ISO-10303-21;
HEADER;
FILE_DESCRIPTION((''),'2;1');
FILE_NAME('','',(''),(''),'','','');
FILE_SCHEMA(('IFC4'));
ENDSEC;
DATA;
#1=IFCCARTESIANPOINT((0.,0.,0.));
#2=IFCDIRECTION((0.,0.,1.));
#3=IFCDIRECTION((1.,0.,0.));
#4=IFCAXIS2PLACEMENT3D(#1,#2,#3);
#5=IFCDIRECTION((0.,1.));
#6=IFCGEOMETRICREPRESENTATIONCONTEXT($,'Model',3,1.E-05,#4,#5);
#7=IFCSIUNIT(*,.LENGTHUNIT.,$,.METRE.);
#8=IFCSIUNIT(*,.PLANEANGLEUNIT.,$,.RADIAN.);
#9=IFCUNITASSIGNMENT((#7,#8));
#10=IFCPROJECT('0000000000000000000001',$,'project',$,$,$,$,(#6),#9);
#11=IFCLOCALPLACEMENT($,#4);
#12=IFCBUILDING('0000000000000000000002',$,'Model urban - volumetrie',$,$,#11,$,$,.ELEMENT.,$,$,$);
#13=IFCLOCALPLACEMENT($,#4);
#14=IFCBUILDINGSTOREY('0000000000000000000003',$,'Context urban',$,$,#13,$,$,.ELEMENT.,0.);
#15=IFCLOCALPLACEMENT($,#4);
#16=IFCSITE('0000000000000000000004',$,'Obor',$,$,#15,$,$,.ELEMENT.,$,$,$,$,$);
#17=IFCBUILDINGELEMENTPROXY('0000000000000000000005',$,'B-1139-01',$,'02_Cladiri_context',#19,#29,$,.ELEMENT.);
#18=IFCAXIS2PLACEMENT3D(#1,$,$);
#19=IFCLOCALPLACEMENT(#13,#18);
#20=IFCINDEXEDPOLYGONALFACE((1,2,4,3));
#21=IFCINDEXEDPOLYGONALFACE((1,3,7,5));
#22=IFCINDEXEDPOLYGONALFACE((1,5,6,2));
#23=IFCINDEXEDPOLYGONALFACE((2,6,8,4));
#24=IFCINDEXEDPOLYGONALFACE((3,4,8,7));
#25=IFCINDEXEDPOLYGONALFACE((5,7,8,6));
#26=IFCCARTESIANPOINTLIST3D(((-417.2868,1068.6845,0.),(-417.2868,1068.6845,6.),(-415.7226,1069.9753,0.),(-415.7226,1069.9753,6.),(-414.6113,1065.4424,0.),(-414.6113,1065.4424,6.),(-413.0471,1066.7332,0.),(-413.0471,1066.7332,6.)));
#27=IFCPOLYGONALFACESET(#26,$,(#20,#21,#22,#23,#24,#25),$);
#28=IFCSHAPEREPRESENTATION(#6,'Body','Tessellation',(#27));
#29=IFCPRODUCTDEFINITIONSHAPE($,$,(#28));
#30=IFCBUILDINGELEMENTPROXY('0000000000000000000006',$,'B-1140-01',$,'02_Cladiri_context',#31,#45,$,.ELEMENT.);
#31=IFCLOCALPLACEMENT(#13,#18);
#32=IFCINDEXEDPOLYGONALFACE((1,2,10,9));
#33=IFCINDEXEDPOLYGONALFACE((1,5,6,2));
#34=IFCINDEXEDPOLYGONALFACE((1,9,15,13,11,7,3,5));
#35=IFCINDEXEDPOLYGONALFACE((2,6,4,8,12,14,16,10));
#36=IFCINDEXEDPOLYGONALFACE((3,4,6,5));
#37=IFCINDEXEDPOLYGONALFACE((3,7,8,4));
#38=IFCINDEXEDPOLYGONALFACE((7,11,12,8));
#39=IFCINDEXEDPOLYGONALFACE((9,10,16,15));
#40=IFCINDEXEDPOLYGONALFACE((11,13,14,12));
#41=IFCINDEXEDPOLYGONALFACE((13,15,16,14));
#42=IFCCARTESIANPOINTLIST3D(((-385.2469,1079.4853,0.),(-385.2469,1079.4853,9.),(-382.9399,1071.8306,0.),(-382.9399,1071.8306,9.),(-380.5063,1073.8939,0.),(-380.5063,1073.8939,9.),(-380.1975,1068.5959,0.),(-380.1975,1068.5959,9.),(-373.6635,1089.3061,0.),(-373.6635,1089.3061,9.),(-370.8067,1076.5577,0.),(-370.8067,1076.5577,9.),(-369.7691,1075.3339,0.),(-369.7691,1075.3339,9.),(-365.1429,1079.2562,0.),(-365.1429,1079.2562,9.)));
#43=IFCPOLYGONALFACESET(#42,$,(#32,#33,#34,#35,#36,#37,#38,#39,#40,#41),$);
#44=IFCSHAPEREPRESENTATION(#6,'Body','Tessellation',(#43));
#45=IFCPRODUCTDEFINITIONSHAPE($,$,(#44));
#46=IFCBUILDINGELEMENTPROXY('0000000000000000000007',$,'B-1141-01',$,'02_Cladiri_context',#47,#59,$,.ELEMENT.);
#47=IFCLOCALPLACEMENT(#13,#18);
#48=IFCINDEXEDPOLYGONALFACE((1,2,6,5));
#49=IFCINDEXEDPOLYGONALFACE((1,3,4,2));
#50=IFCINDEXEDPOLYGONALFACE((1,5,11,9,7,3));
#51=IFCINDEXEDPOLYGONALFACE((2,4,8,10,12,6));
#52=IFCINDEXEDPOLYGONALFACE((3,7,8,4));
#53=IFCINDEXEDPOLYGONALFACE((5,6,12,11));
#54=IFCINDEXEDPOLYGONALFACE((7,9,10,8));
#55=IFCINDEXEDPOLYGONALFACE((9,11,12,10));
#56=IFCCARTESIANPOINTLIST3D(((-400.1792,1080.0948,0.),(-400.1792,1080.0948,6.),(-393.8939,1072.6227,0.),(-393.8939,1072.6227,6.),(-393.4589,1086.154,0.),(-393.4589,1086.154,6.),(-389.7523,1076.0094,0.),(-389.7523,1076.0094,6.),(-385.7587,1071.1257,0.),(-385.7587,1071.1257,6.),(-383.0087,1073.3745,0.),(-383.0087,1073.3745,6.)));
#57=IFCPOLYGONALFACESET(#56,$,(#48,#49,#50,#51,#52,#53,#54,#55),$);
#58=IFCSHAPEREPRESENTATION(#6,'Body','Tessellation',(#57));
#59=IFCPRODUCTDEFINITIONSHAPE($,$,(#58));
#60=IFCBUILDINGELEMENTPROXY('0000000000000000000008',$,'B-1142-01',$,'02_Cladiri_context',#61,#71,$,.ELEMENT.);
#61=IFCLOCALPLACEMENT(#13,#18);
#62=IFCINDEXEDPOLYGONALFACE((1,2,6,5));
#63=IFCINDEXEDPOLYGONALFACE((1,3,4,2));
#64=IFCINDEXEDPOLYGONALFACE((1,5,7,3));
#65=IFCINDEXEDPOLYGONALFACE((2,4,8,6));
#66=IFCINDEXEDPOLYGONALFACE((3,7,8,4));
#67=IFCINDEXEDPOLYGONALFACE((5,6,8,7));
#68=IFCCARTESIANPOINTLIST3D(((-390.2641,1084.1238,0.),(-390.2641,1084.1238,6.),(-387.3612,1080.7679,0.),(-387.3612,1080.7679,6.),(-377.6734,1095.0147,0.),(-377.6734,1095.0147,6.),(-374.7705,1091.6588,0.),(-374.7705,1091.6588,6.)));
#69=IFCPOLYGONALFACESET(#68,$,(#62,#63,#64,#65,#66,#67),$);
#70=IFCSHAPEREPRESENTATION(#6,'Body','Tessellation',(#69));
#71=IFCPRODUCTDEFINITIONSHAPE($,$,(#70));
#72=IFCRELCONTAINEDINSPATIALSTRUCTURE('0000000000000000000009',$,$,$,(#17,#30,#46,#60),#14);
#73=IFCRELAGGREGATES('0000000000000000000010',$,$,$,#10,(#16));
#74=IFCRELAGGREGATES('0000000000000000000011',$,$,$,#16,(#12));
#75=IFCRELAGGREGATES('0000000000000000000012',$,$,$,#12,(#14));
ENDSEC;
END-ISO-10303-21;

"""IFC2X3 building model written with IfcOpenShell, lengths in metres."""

from ifc_helpers import new_model, si_unit, direction, origin_with_axes, place, context, project, spatial, polyline, outline, extrude, element, save


model = new_model("IFC2X3")

# Units and contexts
model_context = context("Model", 3, precision=1e-05, world=origin_with_axes(), true_north=direction((0.0, 1.0)))
ifc_project = project(units=[si_unit("LENGTHUNIT", "METRE"), si_unit("PLANEANGLEUNIT", "RADIAN")], contexts=[model_context])

# Site, building, storey
site_placement = place(None, origin_with_axes())
site = spatial("IfcSite", under=ifc_project, at=site_placement, Name="Obor", CompositionType="ELEMENT")
building_placement = place(None, origin_with_axes())
building = spatial("IfcBuilding", under=site, at=building_placement, Name="Model urban - volumetrie", CompositionType="ELEMENT")
storey_placement = place(None, origin_with_axes())
storey = spatial("IfcBuildingStorey", under=building, at=storey_placement, Name="Context urban", CompositionType="ELEMENT", Elevation=0.0)

# Building element proxies
proxy_1_placement = place(None, origin_with_axes())
element("IfcBuildingElementProxy", 1, at=proxy_1_placement, inside=storey, Name="B-1139-01", ObjectType="02_Cladiri_context", CompositionType="ELEMENT", context=model_context, shape_type="SweptSolid", body=[
    extrude(outline(polyline([(-413.0471, 1066.7332), (-415.7226, 1069.9753), (-417.2868, 1068.6845), (-414.6113, 1065.4424), (-413.0471, 1066.7332)])), origin_with_axes(), (0.0, 0.0, 1.0), 6.0),
])
proxy_2_placement = place(None, origin_with_axes())
element("IfcBuildingElementProxy", 2, at=proxy_2_placement, inside=storey, Name="B-1140-01", ObjectType="02_Cladiri_context", CompositionType="ELEMENT", context=model_context, shape_type="SweptSolid", body=[
    extrude(outline(polyline([(-382.9399, 1071.8306), (-380.1975, 1068.5959), (-370.8067, 1076.5577), (-369.7691, 1075.3339), (-365.1429, 1079.2562), (-373.6635, 1089.3061), (-385.2469, 1079.4853), (-380.5063, 1073.8939), (-382.9399, 1071.8306)])), origin_with_axes(), (0.0, 0.0, 1.0), 9.0),
])
proxy_3_placement = place(None, origin_with_axes())
element("IfcBuildingElementProxy", 3, at=proxy_3_placement, inside=storey, Name="B-1141-01", ObjectType="02_Cladiri_context", CompositionType="ELEMENT", context=model_context, shape_type="SweptSolid", body=[
    extrude(outline(polyline([(-385.7587, 1071.1257), (-383.0087, 1073.3745), (-393.4589, 1086.154), (-400.1792, 1080.0948), (-393.8939, 1072.6227), (-389.7523, 1076.0094), (-385.7587, 1071.1257)])), origin_with_axes(), (0.0, 0.0, 1.0), 6.0),
])
proxy_4_placement = place(None, origin_with_axes())
element("IfcBuildingElementProxy", 4, at=proxy_4_placement, inside=storey, Name="B-1142-01", ObjectType="02_Cladiri_context", CompositionType="ELEMENT", context=model_context, shape_type="SweptSolid", body=[
    extrude(outline(polyline([(-387.3612, 1080.7679), (-374.7705, 1091.6588), (-377.6734, 1095.0147), (-390.2641, 1084.1238), (-387.3612, 1080.7679)])), origin_with_axes(), (0.0, 0.0, 1.0), 6.0),
])

save(model, "model.ifc")
